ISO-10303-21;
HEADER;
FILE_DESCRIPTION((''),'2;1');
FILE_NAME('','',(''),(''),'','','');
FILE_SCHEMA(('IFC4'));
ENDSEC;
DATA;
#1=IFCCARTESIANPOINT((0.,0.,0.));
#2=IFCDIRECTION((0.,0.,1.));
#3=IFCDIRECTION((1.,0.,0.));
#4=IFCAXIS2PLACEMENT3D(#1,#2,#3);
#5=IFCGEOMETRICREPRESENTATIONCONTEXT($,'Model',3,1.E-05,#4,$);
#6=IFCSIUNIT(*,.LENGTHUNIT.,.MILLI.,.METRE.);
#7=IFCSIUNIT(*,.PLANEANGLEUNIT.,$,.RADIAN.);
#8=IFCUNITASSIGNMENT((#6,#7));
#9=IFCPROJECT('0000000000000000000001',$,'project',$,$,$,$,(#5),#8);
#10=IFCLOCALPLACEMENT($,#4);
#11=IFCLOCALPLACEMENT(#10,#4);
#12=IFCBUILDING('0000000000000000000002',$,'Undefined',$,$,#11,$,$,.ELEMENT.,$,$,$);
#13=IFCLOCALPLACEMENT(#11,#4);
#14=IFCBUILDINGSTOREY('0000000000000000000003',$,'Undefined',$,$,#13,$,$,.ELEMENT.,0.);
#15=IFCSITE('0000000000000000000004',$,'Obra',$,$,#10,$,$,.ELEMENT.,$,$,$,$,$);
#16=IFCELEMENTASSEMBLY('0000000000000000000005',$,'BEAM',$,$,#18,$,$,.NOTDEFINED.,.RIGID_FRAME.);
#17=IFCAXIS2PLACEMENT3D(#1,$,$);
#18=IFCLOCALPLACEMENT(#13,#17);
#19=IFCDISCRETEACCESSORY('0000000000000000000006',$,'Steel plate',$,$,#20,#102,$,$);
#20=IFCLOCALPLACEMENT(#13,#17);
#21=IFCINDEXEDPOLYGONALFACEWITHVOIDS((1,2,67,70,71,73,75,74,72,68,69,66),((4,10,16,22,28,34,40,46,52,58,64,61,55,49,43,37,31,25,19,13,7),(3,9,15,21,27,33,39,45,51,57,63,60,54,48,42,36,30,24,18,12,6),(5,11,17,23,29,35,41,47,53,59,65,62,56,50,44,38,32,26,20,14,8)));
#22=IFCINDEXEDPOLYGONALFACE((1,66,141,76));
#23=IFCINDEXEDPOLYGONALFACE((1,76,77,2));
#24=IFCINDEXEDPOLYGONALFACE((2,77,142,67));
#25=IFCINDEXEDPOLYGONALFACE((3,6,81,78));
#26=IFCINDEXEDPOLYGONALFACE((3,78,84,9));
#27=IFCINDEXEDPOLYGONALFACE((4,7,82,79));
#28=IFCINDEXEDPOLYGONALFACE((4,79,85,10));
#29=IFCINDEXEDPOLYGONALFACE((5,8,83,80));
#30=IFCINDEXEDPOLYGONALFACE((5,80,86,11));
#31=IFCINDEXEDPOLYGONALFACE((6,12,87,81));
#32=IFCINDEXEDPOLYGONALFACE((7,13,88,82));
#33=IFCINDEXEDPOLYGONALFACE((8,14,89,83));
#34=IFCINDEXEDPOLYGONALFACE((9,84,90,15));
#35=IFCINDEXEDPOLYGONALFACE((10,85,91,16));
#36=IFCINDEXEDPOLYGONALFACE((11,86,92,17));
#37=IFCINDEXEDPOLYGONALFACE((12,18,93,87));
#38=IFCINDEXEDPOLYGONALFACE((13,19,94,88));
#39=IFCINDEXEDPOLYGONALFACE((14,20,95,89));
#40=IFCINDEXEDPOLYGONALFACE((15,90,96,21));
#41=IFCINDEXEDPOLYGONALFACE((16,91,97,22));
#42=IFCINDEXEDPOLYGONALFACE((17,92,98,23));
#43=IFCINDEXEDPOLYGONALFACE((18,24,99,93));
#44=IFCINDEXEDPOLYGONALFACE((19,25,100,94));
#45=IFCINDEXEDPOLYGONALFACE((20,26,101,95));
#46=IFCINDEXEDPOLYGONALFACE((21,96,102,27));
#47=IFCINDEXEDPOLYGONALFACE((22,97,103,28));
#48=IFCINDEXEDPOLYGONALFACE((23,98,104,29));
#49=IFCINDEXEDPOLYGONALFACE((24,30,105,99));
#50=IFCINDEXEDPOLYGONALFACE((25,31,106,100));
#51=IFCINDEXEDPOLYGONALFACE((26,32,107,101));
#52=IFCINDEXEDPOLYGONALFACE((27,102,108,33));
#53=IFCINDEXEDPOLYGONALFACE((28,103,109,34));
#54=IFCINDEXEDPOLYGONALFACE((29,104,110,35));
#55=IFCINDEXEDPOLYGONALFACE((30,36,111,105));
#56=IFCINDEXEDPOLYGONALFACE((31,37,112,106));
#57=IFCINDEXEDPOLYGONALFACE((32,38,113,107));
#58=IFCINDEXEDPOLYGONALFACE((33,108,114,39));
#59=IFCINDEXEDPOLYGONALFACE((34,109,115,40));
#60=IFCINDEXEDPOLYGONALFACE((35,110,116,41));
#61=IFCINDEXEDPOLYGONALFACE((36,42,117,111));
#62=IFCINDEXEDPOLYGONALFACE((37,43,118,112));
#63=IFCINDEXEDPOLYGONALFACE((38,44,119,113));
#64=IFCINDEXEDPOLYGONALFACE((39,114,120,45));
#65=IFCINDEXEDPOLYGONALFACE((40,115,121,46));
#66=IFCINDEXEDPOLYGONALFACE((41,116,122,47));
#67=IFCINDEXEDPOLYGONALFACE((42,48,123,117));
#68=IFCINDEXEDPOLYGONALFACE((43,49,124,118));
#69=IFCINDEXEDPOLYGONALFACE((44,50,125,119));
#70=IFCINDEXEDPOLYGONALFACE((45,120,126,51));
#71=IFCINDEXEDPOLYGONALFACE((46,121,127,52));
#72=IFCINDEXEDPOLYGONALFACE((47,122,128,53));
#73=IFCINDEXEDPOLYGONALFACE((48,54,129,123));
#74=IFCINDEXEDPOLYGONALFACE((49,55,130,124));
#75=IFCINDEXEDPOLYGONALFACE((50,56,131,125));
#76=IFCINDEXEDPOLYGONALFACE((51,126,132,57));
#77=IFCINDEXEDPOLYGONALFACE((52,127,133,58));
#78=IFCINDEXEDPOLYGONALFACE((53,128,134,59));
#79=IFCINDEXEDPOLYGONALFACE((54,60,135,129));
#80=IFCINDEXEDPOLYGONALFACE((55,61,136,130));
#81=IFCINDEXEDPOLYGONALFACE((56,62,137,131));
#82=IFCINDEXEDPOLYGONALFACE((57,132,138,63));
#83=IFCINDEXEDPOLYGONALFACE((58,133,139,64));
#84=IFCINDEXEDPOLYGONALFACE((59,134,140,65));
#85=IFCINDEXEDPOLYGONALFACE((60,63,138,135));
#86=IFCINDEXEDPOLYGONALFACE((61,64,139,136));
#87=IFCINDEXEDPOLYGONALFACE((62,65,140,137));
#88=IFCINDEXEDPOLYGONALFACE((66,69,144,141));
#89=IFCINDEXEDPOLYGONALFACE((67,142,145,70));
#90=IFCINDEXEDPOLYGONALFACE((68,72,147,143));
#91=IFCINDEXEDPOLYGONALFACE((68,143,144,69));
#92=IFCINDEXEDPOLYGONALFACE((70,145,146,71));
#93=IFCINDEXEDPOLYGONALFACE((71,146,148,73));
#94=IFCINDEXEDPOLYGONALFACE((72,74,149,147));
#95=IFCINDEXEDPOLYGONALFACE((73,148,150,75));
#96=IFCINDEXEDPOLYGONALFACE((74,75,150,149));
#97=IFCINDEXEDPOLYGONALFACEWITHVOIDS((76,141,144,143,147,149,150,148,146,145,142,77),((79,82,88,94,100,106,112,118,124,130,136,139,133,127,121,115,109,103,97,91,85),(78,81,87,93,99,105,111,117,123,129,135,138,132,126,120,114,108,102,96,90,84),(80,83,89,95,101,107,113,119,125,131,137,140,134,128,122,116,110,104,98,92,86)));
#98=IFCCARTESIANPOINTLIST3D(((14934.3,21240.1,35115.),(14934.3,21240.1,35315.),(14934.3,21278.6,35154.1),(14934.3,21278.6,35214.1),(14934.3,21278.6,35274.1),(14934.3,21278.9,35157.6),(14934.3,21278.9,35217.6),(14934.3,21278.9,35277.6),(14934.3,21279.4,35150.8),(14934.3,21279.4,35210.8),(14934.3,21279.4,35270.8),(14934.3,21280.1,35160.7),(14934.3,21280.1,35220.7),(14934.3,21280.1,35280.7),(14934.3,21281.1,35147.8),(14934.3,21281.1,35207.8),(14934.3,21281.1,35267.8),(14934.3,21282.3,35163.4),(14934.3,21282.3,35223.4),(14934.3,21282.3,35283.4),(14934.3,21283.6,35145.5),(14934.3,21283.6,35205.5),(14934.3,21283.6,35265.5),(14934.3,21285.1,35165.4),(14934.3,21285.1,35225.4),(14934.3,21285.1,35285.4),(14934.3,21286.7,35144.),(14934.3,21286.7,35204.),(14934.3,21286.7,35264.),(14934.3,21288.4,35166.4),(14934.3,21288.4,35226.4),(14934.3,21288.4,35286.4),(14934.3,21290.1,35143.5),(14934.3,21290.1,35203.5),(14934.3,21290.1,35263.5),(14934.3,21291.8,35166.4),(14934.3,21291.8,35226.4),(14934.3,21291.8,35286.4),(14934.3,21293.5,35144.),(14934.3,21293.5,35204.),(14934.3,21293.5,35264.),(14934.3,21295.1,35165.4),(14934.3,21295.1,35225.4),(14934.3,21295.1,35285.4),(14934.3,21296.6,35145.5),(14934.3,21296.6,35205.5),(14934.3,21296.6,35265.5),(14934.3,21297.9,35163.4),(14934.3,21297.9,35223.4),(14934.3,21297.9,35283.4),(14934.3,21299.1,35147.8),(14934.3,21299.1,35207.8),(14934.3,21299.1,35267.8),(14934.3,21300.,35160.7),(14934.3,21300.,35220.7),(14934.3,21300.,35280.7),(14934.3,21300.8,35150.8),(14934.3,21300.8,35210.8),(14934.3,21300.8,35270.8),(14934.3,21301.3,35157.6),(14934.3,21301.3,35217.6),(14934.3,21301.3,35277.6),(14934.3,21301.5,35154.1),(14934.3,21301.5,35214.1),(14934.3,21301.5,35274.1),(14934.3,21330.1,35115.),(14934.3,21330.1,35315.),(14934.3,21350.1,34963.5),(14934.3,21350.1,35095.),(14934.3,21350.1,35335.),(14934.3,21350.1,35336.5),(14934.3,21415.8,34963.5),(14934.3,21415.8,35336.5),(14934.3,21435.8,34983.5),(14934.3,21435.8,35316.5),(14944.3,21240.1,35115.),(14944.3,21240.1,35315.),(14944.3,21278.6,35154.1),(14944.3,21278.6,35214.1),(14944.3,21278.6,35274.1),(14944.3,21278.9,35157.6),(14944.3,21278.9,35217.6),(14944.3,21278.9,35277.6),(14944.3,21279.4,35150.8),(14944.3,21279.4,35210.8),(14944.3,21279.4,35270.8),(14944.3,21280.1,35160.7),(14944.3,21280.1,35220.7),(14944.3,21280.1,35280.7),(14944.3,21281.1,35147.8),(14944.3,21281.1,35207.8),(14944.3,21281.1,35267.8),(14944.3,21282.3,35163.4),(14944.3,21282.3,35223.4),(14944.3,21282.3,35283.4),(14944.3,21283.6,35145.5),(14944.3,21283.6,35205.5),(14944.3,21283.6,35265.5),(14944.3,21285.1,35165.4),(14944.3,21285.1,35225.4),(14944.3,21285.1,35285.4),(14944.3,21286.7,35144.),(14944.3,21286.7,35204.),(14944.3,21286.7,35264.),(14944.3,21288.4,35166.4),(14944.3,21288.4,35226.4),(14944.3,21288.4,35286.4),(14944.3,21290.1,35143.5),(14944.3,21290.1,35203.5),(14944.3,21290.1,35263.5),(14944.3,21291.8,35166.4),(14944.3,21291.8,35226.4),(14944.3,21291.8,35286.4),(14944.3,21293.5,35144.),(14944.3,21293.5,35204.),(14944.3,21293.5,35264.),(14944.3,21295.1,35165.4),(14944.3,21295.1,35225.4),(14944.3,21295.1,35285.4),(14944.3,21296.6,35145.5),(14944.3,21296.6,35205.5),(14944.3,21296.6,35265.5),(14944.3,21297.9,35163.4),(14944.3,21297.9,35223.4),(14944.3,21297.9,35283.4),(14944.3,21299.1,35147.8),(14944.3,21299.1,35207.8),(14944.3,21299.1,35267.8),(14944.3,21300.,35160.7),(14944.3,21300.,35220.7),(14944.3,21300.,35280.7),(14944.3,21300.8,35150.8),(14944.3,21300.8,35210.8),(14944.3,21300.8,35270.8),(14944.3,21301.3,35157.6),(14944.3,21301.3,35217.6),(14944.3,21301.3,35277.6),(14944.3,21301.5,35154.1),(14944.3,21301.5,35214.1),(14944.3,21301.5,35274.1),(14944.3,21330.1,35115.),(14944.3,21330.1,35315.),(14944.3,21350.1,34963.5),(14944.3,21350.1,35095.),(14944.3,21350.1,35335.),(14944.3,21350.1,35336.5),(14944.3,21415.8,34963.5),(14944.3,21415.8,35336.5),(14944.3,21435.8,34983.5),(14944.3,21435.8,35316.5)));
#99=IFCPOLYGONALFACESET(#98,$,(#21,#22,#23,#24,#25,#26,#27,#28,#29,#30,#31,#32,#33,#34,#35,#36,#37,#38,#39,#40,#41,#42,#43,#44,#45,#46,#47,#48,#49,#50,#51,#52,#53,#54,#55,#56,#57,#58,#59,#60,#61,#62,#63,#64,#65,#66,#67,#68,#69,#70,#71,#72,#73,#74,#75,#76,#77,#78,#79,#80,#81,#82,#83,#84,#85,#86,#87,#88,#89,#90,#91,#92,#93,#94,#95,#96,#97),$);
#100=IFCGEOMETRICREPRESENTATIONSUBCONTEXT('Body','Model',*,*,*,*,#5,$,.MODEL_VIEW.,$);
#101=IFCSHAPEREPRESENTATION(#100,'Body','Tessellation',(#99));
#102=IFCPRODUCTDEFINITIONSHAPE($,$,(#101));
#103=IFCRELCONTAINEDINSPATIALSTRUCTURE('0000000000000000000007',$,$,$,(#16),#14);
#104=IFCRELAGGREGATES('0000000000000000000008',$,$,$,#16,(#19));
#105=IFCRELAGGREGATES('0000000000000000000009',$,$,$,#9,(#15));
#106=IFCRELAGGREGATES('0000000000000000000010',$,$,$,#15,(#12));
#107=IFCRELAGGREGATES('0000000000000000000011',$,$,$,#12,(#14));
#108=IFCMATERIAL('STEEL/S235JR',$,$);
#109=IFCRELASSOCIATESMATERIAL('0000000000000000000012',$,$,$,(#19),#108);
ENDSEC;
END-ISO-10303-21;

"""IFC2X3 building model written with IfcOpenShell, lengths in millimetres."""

from ifc_helpers import new_model, si_unit, frame, origin_with_axes, origin_2d_with_axis, place, context, subcontext, project, spatial, polyline, circle, outline, extrude, source, transform, mapped, material, element, aggregate, save


model = new_model("IFC2X3")

# Units and contexts
model_context = context("Model", 3, precision=1e-05, world=origin_with_axes())
body_context = subcontext(model_context, "Body", "Model", "MODEL_VIEW")
ifc_project = project(units=[si_unit("LENGTHUNIT", "METRE", prefix="MILLI"), si_unit("PLANEANGLEUNIT", "RADIAN")], contexts=[model_context])

# Site, building, storey
site_placement = place(None, origin_with_axes())
site = spatial("IfcSite", under=ifc_project, at=site_placement, Name="Obra", CompositionType="ELEMENT")
building_placement = place(site_placement, origin_with_axes())
building = spatial("IfcBuilding", under=site, at=building_placement, Name="Undefined", CompositionType="ELEMENT")
storey_placement = place(building_placement, origin_with_axes())
storey = spatial("IfcBuildingStorey", under=building, at=storey_placement, Name="Undefined", CompositionType="ELEMENT", Elevation=0.0)

# Element assembly
assembly_1_placement = place(storey_placement, origin_with_axes())
assembly_1 = element("IfcElementAssembly", 1, at=assembly_1_placement, inside=storey, Name="BEAM", AssemblyPlace="NOTDEFINED", PredefinedType="RIGID_FRAME")
ifc_material_1 = material(Name="STEEL/S235JR")

# Discrete accessory, opening
discrete_accessory_1_placement = place(assembly_1_placement, frame((14939.3, 21435.8, 34983.5), z_axis=(-1.0, -0.000013, 0.0), x_axis=(0.000009, -0.707107, -0.707107)))
discrete_accessory_1 = element("IfcDiscreteAccessory", 2, at=discrete_accessory_1_placement, material=ifc_material_1, Name="Steel plate", context=body_context, shape_type="SweptSolid", body=[
    extrude(outline(polyline([(0.0, 0.0), (28.3, 0.0), (74.7, 46.5), (-18.2, 139.4), (-18.2, 167.7), (45.4, 231.4), (-96.0, 372.8), (-159.7, 309.1), (-187.9, 309.1), (-189.0, 310.2), (-235.5, 263.8), (-235.5, 235.5), (0.0, 0.0)])), frame((0.0, 0.0, -5.0), z_axis=(0.0, 0.0, 1.0), x_axis=(1.0, 0.0, 0.0)), (0.0, 0.0, 1.0), 10.0),
])
shared_shape_1 = source(origin_with_axes(), body_context, "Body", "SweptSolid", [
    extrude(circle(Radius=11.5, at=origin_2d_with_axis()), frame((0.0, -13.4, 0.0), z_axis=(0.0, 1.0, 0.0), x_axis=(1.0, 0.0, 0.0)), (0.0, 0.0, 1.0), 10.2),
])
opening_1_placement = place(assembly_1_placement, frame((14947.6, 21340.1, 35315.0), z_axis=(0.000013, -1.0, 0.0), x_axis=(0.0, 0.0, -1.0)))
element("IfcOpeningElement", 3, at=opening_1_placement, cuts=discrete_accessory_1, ObjectType="Opening", context=body_context, shape_type="MappedRepresentation", body=[
    mapped(shared_shape_1, transform((40.0, 0.0, 50.0))),
    mapped(shared_shape_1, transform((100.0, 0.0, 50.0))),
    mapped(shared_shape_1, transform((160.0, 0.0, 50.0))),
])
aggregate(assembly_1, [discrete_accessory_1])

save(model, "model.ifc")
